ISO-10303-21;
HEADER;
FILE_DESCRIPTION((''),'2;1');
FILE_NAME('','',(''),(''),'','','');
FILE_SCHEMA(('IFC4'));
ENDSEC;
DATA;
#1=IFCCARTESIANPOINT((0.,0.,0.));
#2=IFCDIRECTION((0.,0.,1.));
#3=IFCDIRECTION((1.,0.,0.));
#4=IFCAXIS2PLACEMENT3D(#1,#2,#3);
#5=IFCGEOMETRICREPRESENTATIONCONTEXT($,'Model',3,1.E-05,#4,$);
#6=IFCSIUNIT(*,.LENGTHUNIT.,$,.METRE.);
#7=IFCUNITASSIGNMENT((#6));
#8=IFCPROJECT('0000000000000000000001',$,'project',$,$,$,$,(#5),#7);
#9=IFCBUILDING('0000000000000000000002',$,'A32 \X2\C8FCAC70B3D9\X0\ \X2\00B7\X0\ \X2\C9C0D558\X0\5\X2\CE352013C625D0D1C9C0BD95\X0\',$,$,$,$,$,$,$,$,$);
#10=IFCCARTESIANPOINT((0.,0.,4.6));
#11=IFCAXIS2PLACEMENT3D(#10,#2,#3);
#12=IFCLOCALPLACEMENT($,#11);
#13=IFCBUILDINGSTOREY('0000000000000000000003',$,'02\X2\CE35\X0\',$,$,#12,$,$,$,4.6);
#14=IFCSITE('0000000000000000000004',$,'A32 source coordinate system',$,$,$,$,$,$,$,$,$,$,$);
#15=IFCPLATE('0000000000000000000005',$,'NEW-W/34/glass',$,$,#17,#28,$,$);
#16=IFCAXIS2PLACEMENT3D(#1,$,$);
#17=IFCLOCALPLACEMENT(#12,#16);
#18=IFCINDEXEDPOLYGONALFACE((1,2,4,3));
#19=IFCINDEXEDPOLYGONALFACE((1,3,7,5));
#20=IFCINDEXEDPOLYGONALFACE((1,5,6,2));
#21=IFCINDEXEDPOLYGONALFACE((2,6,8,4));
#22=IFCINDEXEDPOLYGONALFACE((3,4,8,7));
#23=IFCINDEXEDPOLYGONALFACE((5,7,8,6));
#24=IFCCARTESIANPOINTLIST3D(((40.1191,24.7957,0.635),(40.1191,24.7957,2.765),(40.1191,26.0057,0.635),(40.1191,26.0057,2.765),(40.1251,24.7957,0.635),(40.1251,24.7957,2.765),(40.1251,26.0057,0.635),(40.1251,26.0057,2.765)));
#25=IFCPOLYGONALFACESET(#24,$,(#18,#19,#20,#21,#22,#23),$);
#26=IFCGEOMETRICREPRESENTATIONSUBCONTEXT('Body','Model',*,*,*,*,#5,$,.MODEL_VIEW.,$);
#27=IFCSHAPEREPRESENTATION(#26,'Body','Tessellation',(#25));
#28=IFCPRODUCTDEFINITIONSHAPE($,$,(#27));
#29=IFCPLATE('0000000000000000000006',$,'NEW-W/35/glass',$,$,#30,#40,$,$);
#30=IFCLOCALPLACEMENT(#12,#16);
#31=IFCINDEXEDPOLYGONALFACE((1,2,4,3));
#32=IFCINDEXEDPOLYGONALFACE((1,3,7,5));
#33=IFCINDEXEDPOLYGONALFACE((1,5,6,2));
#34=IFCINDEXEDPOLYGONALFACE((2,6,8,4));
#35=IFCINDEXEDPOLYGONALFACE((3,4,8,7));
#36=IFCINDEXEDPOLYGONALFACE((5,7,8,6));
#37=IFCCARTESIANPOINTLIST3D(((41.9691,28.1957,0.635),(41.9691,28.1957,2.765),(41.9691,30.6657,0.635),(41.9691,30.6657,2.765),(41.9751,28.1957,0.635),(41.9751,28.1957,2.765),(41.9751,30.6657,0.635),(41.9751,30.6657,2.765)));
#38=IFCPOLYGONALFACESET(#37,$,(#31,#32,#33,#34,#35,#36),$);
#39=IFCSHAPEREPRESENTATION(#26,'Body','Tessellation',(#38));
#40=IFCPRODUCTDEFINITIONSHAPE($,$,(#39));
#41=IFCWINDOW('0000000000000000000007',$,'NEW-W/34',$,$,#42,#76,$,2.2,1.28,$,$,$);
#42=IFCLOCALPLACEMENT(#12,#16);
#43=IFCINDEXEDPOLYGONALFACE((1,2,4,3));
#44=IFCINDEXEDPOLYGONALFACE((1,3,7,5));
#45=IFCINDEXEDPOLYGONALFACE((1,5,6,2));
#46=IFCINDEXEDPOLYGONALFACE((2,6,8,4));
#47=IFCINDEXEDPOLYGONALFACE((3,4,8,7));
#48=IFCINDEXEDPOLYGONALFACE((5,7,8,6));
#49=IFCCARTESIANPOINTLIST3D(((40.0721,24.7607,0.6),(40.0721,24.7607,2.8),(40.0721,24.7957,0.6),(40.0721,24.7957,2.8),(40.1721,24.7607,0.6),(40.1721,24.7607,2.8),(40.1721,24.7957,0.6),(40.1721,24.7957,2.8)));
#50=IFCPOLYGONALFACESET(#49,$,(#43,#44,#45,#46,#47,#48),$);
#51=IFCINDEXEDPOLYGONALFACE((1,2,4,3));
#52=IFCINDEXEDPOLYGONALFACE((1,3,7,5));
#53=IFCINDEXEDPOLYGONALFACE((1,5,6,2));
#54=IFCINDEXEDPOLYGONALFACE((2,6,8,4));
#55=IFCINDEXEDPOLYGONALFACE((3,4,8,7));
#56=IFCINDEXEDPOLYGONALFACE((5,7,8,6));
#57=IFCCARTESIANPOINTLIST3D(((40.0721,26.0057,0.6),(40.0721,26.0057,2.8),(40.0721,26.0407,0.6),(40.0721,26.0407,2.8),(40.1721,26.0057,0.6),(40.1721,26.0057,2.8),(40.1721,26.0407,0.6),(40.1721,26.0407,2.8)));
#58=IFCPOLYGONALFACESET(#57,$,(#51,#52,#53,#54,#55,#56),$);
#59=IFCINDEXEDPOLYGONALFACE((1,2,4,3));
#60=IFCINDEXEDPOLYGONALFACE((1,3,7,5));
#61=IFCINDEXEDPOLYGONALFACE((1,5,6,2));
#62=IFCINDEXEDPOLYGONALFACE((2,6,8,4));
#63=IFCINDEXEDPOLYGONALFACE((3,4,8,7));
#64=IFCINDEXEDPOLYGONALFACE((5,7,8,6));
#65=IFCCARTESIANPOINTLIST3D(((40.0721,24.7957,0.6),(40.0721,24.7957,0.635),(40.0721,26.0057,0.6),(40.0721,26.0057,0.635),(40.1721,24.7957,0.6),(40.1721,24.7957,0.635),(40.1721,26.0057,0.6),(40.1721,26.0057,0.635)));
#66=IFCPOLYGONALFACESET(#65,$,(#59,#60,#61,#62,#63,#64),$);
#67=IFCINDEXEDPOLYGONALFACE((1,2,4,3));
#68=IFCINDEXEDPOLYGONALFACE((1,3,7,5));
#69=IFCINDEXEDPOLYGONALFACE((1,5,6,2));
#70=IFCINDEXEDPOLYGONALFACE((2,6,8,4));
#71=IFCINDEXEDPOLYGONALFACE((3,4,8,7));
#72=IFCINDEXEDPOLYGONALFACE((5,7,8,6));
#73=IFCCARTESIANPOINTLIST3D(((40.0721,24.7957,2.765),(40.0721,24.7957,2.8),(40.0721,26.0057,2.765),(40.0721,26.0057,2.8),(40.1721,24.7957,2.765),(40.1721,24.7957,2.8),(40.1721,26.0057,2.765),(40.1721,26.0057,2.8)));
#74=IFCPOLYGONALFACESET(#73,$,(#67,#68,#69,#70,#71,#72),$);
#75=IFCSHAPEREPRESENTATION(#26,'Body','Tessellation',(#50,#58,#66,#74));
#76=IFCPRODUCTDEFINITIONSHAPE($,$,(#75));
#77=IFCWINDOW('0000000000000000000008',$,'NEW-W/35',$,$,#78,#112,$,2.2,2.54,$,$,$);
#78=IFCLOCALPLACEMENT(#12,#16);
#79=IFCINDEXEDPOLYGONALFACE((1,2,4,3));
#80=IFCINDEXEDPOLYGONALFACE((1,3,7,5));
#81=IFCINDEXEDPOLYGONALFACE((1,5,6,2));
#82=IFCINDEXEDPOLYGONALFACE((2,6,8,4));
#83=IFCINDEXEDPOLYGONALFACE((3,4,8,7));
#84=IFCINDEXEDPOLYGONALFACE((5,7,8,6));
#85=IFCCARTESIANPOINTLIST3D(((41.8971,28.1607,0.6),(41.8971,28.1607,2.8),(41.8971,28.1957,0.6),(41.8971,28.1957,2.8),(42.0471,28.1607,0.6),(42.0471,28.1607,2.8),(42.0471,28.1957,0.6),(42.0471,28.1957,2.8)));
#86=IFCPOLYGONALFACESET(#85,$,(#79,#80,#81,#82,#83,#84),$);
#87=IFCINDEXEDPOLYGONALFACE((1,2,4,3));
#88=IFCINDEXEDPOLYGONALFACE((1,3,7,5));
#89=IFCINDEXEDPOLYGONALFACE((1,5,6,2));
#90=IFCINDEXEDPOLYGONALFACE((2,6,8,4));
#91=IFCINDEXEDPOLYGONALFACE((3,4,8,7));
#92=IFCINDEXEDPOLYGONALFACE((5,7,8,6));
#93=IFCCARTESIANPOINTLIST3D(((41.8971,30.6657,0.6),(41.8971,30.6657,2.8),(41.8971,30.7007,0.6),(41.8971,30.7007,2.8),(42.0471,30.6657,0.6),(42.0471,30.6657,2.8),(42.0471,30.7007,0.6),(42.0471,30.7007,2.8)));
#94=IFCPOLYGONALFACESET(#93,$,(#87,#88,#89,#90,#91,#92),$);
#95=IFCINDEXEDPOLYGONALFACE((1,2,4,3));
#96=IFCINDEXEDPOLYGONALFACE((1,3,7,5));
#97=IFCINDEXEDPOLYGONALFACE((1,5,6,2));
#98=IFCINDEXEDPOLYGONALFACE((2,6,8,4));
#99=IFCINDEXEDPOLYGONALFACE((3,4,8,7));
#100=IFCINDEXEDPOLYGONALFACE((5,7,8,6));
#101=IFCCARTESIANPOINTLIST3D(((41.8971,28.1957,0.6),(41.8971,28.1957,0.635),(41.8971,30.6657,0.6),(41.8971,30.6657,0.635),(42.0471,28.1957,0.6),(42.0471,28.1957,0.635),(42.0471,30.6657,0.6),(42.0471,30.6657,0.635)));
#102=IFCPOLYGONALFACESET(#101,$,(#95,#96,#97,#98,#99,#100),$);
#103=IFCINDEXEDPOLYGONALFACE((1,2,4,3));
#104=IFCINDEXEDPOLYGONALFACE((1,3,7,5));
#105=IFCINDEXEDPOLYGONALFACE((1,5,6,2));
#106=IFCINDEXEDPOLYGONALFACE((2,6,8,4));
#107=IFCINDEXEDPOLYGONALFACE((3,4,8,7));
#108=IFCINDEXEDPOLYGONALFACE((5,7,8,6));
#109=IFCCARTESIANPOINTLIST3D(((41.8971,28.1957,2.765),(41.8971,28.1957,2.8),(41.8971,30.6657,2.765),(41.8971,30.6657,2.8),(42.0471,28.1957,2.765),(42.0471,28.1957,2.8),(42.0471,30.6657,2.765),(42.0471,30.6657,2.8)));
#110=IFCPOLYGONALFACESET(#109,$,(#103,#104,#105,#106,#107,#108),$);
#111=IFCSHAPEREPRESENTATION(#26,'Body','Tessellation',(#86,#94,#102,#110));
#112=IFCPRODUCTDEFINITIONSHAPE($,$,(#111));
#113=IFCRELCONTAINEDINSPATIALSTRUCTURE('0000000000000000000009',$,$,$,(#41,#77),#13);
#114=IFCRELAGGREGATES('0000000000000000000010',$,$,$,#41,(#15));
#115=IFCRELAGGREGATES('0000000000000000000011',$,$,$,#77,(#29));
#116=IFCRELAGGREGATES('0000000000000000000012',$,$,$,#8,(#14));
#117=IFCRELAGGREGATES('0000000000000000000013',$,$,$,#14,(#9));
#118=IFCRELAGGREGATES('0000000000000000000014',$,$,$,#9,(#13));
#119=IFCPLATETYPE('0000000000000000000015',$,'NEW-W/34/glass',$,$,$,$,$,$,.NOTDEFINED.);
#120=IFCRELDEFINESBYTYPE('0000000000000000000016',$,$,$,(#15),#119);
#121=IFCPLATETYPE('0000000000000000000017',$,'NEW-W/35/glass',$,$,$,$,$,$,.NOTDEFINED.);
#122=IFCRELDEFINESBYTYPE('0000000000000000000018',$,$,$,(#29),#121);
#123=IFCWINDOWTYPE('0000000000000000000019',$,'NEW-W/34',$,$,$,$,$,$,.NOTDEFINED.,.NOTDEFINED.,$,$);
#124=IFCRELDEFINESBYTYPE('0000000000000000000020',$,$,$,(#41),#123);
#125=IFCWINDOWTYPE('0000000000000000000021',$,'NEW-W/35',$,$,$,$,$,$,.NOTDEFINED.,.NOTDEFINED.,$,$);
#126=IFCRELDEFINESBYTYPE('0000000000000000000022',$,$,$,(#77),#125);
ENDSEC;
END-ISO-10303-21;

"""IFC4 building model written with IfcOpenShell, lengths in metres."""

from ifc_helpers import new_model, si_unit, frame, origin, origin_with_axes, place, context, subcontext, project, spatial, polyline, outline, extrude, source, transform, mapped, type_object, type_shapes, element, aggregate, save


model = new_model("IFC4")

# Units and contexts
model_context = context("Model", 3, precision=1e-05, world=origin_with_axes())
body_context = subcontext(model_context, "Body", "Model", "MODEL_VIEW")
ifc_project = project(units=[si_unit("LENGTHUNIT", "METRE")], contexts=[model_context])

# Plates
storey_placement = place(None, frame((0.0, 0.0, 4.6), z_axis=(0.0, 0.0, 1.0), x_axis=(1.0, 0.0, 0.0)))
plate_type_1 = type_object("IfcPlateType", Name="NEW-W/34/glass", PredefinedType="NOTDEFINED")
shared_shape_1 = source(origin(), body_context, "Body", "SweptSolid", [
    extrude(outline(polyline([(40.1251, 24.7957), (40.1191, 24.7957), (40.1191, 26.0057), (40.1251, 26.0057), (40.1251, 24.7957)])), frame((0.0, 0.0, 0.635)), (0.0, 0.0, 1.0), 2.13),
])
type_shapes(plate_type_1, [shared_shape_1])
window_1_placement = place(storey_placement, origin_with_axes())
plate_1_placement = place(window_1_placement, origin_with_axes())
plate_1 = element("IfcPlate", 1, at=plate_1_placement, type_object=plate_type_1, Name="NEW-W/34/glass", context=body_context, shape_type="MappedRepresentation", body=[
    mapped(shared_shape_1, transform((0.0, 0.0, 0.0), scale=1.0)),
])
plate_type_2 = type_object("IfcPlateType", Name="NEW-W/35/glass", PredefinedType="NOTDEFINED")
shared_shape_2 = source(origin(), body_context, "Body", "SweptSolid", [
    extrude(outline(polyline([(41.9751, 28.1957), (41.9691, 28.1957), (41.9691, 30.6657), (41.9751, 30.6657), (41.9751, 28.1957)])), frame((0.0, 0.0, 0.635)), (0.0, 0.0, 1.0), 2.13),
])
type_shapes(plate_type_2, [shared_shape_2])
window_2_placement = place(storey_placement, origin_with_axes())
plate_2_placement = place(window_2_placement, origin_with_axes())
plate_2 = element("IfcPlate", 2, at=plate_2_placement, type_object=plate_type_2, Name="NEW-W/35/glass", context=body_context, shape_type="MappedRepresentation", body=[
    mapped(shared_shape_2, transform((0.0, 0.0, 0.0), scale=1.0)),
])

# Site, building, storey
site = spatial("IfcSite", under=ifc_project, Name="A32 source coordinate system")
building = spatial("IfcBuilding", under=site, Name="A32 주거동 · 지하5층–옥탑지붕")
storey = spatial("IfcBuildingStorey", under=building, at=storey_placement, Name="02층", Elevation=4.6)

# Windows
window_type_1 = type_object("IfcWindowType", Name="NEW-W/34", PartitioningType="NOTDEFINED", PredefinedType="NOTDEFINED")
shared_shape_3 = source(origin(), body_context, "Body", "SweptSolid", [
    extrude(outline(polyline([(40.0721, 24.7607), (40.0721, 24.7957), (40.1721, 24.7957), (40.1721, 24.7607), (40.0721, 24.7607)])), frame((0.0, 0.0, 0.6)), (0.0, 0.0, 1.0), 2.2),
    extrude(outline(polyline([(40.0721, 26.0057), (40.0721, 26.0407), (40.1721, 26.0407), (40.1721, 26.0057), (40.0721, 26.0057)])), frame((0.0, 0.0, 0.6)), (0.0, 0.0, 1.0), 2.2),
    extrude(outline(polyline([(40.1721, 24.7957), (40.1721, 26.0057), (40.0721, 26.0057), (40.0721, 24.7957), (40.1721, 24.7957)])), frame((0.0, 0.0, 0.6)), (0.0, 0.0, 1.0), 0.035),
    extrude(outline(polyline([(40.1721, 24.7957), (40.1721, 26.0057), (40.0721, 26.0057), (40.0721, 24.7957), (40.1721, 24.7957)])), frame((0.0, 0.0, 2.765)), (0.0, 0.0, 1.0), 0.035),
])
type_shapes(window_type_1, [shared_shape_3])
window_1 = element("IfcWindow", 3, at=window_1_placement, inside=storey, type_object=window_type_1, Name="NEW-W/34", OverallHeight=2.2, OverallWidth=1.28, context=body_context, shape_type="MappedRepresentation", body=[
    mapped(shared_shape_3, transform((0.0, 0.0, 0.0), scale=1.0)),
])
aggregate(window_1, [plate_1])
window_type_2 = type_object("IfcWindowType", Name="NEW-W/35", PartitioningType="NOTDEFINED", PredefinedType="NOTDEFINED")
shared_shape_4 = source(origin(), body_context, "Body", "SweptSolid", [
    extrude(outline(polyline([(41.8971, 28.1607), (41.8971, 28.1957), (42.0471, 28.1957), (42.0471, 28.1607), (41.8971, 28.1607)])), frame((0.0, 0.0, 0.6)), (0.0, 0.0, 1.0), 2.2),
    extrude(outline(polyline([(41.8971, 30.6657), (41.8971, 30.7007), (42.0471, 30.7007), (42.0471, 30.6657), (41.8971, 30.6657)])), frame((0.0, 0.0, 0.6)), (0.0, 0.0, 1.0), 2.2),
    extrude(outline(polyline([(42.0471, 28.1957), (42.0471, 30.6657), (41.8971, 30.6657), (41.8971, 28.1957), (42.0471, 28.1957)])), frame((0.0, 0.0, 0.6)), (0.0, 0.0, 1.0), 0.035),
    extrude(outline(polyline([(42.0471, 28.1957), (42.0471, 30.6657), (41.8971, 30.6657), (41.8971, 28.1957), (42.0471, 28.1957)])), frame((0.0, 0.0, 2.765)), (0.0, 0.0, 1.0), 0.035),
])
type_shapes(window_type_2, [shared_shape_4])
window_2 = element("IfcWindow", 4, at=window_2_placement, inside=storey, type_object=window_type_2, Name="NEW-W/35", OverallHeight=2.2, OverallWidth=2.54, context=body_context, shape_type="MappedRepresentation", body=[
    mapped(shared_shape_4, transform((0.0, 0.0, 0.0), scale=1.0)),
])
aggregate(window_2, [plate_2])

save(model, "model.ifc")
